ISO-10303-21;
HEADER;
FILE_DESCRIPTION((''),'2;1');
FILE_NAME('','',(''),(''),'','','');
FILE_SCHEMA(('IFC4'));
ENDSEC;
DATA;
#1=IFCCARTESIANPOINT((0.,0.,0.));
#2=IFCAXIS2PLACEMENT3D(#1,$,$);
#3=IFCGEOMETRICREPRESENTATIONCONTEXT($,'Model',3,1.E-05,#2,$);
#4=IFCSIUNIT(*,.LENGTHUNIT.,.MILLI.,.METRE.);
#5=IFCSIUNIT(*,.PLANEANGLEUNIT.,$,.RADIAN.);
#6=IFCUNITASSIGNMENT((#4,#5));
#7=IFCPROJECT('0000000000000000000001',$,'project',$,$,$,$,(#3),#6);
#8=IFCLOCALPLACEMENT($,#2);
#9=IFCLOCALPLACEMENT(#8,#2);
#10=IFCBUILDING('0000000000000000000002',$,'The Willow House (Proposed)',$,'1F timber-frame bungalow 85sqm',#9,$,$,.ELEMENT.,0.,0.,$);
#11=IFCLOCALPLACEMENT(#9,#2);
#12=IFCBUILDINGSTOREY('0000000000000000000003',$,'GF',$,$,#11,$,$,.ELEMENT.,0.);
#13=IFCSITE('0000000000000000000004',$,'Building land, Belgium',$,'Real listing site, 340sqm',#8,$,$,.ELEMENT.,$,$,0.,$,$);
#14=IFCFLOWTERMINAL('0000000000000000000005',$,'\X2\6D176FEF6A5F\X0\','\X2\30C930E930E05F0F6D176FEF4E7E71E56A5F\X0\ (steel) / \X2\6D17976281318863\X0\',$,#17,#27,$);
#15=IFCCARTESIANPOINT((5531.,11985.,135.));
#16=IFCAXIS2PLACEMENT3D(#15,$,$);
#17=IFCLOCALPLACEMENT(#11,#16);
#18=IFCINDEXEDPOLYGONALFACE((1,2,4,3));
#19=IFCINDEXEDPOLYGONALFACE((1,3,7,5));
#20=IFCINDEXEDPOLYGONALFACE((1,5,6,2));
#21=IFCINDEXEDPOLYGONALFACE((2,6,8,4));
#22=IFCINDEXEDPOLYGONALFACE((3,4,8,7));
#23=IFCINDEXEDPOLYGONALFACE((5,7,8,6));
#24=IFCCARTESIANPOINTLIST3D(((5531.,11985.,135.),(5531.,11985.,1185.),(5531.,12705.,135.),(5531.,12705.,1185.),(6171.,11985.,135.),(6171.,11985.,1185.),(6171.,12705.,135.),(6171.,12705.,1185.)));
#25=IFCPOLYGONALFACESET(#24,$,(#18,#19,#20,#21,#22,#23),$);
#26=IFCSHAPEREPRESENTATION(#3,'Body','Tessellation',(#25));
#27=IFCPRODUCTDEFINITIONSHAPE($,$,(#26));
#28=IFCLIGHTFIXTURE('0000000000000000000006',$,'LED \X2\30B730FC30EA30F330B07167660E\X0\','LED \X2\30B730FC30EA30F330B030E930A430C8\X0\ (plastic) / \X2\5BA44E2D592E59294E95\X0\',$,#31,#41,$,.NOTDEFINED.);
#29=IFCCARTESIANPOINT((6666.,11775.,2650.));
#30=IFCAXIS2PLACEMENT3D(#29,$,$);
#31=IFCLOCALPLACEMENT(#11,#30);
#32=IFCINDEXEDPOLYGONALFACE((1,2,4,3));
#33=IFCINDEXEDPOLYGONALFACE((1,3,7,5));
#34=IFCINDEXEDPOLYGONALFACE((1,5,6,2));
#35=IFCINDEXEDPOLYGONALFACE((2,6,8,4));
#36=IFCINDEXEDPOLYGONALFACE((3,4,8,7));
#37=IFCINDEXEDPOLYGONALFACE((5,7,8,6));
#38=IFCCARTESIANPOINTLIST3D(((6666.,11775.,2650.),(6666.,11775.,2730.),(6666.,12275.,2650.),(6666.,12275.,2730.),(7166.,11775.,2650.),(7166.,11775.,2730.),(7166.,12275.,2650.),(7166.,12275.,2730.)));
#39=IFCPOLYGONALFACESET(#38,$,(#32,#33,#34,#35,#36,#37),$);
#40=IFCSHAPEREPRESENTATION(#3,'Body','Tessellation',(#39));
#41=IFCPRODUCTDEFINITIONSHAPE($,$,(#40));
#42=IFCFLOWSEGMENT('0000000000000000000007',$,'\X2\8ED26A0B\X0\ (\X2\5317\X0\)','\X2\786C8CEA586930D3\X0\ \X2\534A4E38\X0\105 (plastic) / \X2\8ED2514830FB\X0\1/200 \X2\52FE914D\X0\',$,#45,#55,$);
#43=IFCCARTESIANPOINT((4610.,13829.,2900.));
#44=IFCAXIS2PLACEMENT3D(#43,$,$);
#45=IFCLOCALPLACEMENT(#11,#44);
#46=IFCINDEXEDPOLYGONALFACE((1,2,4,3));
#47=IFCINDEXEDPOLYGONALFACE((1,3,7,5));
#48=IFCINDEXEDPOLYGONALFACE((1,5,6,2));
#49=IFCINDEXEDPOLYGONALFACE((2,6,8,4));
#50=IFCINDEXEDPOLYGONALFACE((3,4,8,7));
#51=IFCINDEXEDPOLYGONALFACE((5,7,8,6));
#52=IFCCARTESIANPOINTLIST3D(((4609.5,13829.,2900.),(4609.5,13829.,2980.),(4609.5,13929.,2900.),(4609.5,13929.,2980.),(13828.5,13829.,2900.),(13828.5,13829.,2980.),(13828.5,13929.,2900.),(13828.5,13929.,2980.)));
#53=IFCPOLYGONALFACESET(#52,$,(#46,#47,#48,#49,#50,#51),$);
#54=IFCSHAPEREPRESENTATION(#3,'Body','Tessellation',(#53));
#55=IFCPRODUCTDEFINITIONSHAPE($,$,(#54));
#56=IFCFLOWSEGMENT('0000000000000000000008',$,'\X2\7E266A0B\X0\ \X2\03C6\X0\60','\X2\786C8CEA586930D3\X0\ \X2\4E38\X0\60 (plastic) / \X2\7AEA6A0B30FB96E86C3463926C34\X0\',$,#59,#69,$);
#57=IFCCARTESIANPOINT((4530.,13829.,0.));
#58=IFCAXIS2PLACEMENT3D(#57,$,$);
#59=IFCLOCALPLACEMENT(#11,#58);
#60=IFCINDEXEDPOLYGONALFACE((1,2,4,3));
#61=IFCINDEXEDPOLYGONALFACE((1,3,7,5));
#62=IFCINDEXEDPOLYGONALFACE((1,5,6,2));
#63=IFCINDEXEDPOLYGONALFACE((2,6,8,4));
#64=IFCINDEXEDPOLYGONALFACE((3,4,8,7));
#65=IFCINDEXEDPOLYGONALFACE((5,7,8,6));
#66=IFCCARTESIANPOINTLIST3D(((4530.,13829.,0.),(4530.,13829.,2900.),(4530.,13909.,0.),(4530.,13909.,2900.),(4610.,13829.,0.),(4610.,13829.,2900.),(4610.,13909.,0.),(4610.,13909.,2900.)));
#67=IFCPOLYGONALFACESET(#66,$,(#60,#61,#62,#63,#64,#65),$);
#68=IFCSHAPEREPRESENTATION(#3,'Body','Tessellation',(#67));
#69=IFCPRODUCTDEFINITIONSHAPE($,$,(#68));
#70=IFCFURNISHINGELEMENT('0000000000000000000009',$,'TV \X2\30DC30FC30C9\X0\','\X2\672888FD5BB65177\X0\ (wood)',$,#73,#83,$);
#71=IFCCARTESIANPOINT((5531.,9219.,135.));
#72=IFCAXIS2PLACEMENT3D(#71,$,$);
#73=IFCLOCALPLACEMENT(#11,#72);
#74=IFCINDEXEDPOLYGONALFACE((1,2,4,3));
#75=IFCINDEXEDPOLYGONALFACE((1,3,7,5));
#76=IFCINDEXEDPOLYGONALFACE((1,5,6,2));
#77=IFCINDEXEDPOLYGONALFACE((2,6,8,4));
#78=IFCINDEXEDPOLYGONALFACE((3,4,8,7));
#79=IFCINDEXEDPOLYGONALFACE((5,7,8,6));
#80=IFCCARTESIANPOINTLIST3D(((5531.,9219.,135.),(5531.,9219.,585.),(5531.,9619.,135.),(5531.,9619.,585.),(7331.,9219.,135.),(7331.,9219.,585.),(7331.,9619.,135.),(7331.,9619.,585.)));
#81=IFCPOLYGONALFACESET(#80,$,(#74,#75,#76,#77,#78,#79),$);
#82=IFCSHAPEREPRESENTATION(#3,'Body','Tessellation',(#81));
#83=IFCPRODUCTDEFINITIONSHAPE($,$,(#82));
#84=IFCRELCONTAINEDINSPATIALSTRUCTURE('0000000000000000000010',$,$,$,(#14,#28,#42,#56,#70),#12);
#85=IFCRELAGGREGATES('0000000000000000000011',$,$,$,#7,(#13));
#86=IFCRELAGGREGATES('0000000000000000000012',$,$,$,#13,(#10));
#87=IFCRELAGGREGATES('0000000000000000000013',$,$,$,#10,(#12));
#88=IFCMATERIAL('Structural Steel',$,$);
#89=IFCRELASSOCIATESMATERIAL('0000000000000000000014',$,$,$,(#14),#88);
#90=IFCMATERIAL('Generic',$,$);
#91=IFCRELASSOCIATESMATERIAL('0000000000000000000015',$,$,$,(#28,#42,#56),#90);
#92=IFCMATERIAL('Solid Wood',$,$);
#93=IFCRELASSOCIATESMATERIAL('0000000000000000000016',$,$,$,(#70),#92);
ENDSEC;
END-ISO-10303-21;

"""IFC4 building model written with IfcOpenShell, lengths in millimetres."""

from ifc_helpers import new_model, si_unit, frame, frame_2d, origin, place, context, project, spatial, rectangle, extrude, material, element, save


model = new_model("IFC4")

# Units and contexts
model_context = context("Model", 3, precision=1e-05, world=origin())
ifc_project = project(units=[si_unit("LENGTHUNIT", "METRE", prefix="MILLI"), si_unit("PLANEANGLEUNIT", "RADIAN")], contexts=[model_context])

# Site, building, storey
site_placement = place(None, origin())
site = spatial("IfcSite", under=ifc_project, at=site_placement, Name="Building land, Belgium", ObjectType="Real listing site, 340sqm", CompositionType="ELEMENT", RefElevation=0.0)
building_placement = place(site_placement, origin())
building = spatial("IfcBuilding", under=site, at=building_placement, Name="The Willow House (Proposed)", ObjectType="1F timber-frame bungalow 85sqm", CompositionType="ELEMENT", ElevationOfRefHeight=0.0, ElevationOfTerrain=0.0)
storey_placement = place(building_placement, origin())
storey = spatial("IfcBuildingStorey", under=building, at=storey_placement, Name="GF", CompositionType="ELEMENT", Elevation=0.0)

# Shared definitions
ifc_material_1 = material(Name="Solid Wood")

# Shared definitions
ifc_material_2 = material(Name="Generic")

# Shared definitions
ifc_material_3 = material(Name="Structural Steel")

# Flow terminal
flow_terminal_placement = place(storey_placement, frame((5531.0, 11985.0, 135.0)))
element("IfcFlowTerminal", 1, at=flow_terminal_placement, inside=storey, material=ifc_material_3, Name="洗濯機", Description="ドラム式洗濯乾燥機 (steel) / 洗面脱衣", context=model_context, shape_type="SweptSolid", body=[
    extrude(rectangle(XDim=640.0, YDim=720.0, at=frame_2d((320.0, 360.0))), frame((5531.0, 11985.0, 135.0)), (0.0, 0.0, 1.0), 1050.0),
])

# Light fixture
light_fixture_placement = place(storey_placement, frame((6666.0, 11775.0, 2650.0)))
element("IfcLightFixture", 2, at=light_fixture_placement, inside=storey, material=ifc_material_2, Name="LED シーリング照明", Description="LED シーリングライト (plastic) / 室中央天井", PredefinedType="NOTDEFINED", context=model_context, shape_type="SweptSolid", body=[
    extrude(rectangle(XDim=500.0, YDim=500.0, at=frame_2d((250.0, 250.0))), frame((6666.0, 11775.0, 2650.0)), (0.0, 0.0, 1.0), 80.0),
])

# Flow segments
flow_segment_1_placement = place(storey_placement, frame((4610.0, 13829.0, 2900.0)))
element("IfcFlowSegment", 3, at=flow_segment_1_placement, inside=storey, material=ifc_material_2, Name="軒樋 (北)", Description="硬質塩ビ 半丸105 (plastic) / 軒先・1/200 勾配", context=model_context, shape_type="SweptSolid", body=[
    extrude(rectangle(XDim=9219.0, YDim=100.0, at=frame_2d((4609.0, 50.0))), frame((4610.0, 13829.0, 2900.0)), (0.0, 0.0, 1.0), 80.0),
])
flow_segment_2_placement = place(storey_placement, frame((4530.0, 13829.0, 0.0)))
element("IfcFlowSegment", 4, at=flow_segment_2_placement, inside=storey, material=ifc_material_2, Name="縦樋 φ60", Description="硬質塩ビ 丸60 (plastic) / 竪樋・雨水排水", context=model_context, shape_type="SweptSolid", body=[
    extrude(rectangle(XDim=80.0, YDim=80.0, at=frame_2d((40.0, 40.0))), frame((4530.0, 13829.0, 0.0)), (0.0, 0.0, 1.0), 2900.0),
])

# Furnishing element
furnishing_placement = place(storey_placement, frame((5531.0, 9219.0, 135.0)))
element("IfcFurnishingElement", 5, at=furnishing_placement, inside=storey, material=ifc_material_1, Name="TV ボード", Description="木製家具 (wood)", context=model_context, shape_type="SweptSolid", body=[
    extrude(rectangle(XDim=1800.0, YDim=400.0, at=frame_2d((900.0, 200.0))), frame((5531.0, 9219.0, 135.0)), (0.0, 0.0, 1.0), 450.0),
])

save(model, "model.ifc")
